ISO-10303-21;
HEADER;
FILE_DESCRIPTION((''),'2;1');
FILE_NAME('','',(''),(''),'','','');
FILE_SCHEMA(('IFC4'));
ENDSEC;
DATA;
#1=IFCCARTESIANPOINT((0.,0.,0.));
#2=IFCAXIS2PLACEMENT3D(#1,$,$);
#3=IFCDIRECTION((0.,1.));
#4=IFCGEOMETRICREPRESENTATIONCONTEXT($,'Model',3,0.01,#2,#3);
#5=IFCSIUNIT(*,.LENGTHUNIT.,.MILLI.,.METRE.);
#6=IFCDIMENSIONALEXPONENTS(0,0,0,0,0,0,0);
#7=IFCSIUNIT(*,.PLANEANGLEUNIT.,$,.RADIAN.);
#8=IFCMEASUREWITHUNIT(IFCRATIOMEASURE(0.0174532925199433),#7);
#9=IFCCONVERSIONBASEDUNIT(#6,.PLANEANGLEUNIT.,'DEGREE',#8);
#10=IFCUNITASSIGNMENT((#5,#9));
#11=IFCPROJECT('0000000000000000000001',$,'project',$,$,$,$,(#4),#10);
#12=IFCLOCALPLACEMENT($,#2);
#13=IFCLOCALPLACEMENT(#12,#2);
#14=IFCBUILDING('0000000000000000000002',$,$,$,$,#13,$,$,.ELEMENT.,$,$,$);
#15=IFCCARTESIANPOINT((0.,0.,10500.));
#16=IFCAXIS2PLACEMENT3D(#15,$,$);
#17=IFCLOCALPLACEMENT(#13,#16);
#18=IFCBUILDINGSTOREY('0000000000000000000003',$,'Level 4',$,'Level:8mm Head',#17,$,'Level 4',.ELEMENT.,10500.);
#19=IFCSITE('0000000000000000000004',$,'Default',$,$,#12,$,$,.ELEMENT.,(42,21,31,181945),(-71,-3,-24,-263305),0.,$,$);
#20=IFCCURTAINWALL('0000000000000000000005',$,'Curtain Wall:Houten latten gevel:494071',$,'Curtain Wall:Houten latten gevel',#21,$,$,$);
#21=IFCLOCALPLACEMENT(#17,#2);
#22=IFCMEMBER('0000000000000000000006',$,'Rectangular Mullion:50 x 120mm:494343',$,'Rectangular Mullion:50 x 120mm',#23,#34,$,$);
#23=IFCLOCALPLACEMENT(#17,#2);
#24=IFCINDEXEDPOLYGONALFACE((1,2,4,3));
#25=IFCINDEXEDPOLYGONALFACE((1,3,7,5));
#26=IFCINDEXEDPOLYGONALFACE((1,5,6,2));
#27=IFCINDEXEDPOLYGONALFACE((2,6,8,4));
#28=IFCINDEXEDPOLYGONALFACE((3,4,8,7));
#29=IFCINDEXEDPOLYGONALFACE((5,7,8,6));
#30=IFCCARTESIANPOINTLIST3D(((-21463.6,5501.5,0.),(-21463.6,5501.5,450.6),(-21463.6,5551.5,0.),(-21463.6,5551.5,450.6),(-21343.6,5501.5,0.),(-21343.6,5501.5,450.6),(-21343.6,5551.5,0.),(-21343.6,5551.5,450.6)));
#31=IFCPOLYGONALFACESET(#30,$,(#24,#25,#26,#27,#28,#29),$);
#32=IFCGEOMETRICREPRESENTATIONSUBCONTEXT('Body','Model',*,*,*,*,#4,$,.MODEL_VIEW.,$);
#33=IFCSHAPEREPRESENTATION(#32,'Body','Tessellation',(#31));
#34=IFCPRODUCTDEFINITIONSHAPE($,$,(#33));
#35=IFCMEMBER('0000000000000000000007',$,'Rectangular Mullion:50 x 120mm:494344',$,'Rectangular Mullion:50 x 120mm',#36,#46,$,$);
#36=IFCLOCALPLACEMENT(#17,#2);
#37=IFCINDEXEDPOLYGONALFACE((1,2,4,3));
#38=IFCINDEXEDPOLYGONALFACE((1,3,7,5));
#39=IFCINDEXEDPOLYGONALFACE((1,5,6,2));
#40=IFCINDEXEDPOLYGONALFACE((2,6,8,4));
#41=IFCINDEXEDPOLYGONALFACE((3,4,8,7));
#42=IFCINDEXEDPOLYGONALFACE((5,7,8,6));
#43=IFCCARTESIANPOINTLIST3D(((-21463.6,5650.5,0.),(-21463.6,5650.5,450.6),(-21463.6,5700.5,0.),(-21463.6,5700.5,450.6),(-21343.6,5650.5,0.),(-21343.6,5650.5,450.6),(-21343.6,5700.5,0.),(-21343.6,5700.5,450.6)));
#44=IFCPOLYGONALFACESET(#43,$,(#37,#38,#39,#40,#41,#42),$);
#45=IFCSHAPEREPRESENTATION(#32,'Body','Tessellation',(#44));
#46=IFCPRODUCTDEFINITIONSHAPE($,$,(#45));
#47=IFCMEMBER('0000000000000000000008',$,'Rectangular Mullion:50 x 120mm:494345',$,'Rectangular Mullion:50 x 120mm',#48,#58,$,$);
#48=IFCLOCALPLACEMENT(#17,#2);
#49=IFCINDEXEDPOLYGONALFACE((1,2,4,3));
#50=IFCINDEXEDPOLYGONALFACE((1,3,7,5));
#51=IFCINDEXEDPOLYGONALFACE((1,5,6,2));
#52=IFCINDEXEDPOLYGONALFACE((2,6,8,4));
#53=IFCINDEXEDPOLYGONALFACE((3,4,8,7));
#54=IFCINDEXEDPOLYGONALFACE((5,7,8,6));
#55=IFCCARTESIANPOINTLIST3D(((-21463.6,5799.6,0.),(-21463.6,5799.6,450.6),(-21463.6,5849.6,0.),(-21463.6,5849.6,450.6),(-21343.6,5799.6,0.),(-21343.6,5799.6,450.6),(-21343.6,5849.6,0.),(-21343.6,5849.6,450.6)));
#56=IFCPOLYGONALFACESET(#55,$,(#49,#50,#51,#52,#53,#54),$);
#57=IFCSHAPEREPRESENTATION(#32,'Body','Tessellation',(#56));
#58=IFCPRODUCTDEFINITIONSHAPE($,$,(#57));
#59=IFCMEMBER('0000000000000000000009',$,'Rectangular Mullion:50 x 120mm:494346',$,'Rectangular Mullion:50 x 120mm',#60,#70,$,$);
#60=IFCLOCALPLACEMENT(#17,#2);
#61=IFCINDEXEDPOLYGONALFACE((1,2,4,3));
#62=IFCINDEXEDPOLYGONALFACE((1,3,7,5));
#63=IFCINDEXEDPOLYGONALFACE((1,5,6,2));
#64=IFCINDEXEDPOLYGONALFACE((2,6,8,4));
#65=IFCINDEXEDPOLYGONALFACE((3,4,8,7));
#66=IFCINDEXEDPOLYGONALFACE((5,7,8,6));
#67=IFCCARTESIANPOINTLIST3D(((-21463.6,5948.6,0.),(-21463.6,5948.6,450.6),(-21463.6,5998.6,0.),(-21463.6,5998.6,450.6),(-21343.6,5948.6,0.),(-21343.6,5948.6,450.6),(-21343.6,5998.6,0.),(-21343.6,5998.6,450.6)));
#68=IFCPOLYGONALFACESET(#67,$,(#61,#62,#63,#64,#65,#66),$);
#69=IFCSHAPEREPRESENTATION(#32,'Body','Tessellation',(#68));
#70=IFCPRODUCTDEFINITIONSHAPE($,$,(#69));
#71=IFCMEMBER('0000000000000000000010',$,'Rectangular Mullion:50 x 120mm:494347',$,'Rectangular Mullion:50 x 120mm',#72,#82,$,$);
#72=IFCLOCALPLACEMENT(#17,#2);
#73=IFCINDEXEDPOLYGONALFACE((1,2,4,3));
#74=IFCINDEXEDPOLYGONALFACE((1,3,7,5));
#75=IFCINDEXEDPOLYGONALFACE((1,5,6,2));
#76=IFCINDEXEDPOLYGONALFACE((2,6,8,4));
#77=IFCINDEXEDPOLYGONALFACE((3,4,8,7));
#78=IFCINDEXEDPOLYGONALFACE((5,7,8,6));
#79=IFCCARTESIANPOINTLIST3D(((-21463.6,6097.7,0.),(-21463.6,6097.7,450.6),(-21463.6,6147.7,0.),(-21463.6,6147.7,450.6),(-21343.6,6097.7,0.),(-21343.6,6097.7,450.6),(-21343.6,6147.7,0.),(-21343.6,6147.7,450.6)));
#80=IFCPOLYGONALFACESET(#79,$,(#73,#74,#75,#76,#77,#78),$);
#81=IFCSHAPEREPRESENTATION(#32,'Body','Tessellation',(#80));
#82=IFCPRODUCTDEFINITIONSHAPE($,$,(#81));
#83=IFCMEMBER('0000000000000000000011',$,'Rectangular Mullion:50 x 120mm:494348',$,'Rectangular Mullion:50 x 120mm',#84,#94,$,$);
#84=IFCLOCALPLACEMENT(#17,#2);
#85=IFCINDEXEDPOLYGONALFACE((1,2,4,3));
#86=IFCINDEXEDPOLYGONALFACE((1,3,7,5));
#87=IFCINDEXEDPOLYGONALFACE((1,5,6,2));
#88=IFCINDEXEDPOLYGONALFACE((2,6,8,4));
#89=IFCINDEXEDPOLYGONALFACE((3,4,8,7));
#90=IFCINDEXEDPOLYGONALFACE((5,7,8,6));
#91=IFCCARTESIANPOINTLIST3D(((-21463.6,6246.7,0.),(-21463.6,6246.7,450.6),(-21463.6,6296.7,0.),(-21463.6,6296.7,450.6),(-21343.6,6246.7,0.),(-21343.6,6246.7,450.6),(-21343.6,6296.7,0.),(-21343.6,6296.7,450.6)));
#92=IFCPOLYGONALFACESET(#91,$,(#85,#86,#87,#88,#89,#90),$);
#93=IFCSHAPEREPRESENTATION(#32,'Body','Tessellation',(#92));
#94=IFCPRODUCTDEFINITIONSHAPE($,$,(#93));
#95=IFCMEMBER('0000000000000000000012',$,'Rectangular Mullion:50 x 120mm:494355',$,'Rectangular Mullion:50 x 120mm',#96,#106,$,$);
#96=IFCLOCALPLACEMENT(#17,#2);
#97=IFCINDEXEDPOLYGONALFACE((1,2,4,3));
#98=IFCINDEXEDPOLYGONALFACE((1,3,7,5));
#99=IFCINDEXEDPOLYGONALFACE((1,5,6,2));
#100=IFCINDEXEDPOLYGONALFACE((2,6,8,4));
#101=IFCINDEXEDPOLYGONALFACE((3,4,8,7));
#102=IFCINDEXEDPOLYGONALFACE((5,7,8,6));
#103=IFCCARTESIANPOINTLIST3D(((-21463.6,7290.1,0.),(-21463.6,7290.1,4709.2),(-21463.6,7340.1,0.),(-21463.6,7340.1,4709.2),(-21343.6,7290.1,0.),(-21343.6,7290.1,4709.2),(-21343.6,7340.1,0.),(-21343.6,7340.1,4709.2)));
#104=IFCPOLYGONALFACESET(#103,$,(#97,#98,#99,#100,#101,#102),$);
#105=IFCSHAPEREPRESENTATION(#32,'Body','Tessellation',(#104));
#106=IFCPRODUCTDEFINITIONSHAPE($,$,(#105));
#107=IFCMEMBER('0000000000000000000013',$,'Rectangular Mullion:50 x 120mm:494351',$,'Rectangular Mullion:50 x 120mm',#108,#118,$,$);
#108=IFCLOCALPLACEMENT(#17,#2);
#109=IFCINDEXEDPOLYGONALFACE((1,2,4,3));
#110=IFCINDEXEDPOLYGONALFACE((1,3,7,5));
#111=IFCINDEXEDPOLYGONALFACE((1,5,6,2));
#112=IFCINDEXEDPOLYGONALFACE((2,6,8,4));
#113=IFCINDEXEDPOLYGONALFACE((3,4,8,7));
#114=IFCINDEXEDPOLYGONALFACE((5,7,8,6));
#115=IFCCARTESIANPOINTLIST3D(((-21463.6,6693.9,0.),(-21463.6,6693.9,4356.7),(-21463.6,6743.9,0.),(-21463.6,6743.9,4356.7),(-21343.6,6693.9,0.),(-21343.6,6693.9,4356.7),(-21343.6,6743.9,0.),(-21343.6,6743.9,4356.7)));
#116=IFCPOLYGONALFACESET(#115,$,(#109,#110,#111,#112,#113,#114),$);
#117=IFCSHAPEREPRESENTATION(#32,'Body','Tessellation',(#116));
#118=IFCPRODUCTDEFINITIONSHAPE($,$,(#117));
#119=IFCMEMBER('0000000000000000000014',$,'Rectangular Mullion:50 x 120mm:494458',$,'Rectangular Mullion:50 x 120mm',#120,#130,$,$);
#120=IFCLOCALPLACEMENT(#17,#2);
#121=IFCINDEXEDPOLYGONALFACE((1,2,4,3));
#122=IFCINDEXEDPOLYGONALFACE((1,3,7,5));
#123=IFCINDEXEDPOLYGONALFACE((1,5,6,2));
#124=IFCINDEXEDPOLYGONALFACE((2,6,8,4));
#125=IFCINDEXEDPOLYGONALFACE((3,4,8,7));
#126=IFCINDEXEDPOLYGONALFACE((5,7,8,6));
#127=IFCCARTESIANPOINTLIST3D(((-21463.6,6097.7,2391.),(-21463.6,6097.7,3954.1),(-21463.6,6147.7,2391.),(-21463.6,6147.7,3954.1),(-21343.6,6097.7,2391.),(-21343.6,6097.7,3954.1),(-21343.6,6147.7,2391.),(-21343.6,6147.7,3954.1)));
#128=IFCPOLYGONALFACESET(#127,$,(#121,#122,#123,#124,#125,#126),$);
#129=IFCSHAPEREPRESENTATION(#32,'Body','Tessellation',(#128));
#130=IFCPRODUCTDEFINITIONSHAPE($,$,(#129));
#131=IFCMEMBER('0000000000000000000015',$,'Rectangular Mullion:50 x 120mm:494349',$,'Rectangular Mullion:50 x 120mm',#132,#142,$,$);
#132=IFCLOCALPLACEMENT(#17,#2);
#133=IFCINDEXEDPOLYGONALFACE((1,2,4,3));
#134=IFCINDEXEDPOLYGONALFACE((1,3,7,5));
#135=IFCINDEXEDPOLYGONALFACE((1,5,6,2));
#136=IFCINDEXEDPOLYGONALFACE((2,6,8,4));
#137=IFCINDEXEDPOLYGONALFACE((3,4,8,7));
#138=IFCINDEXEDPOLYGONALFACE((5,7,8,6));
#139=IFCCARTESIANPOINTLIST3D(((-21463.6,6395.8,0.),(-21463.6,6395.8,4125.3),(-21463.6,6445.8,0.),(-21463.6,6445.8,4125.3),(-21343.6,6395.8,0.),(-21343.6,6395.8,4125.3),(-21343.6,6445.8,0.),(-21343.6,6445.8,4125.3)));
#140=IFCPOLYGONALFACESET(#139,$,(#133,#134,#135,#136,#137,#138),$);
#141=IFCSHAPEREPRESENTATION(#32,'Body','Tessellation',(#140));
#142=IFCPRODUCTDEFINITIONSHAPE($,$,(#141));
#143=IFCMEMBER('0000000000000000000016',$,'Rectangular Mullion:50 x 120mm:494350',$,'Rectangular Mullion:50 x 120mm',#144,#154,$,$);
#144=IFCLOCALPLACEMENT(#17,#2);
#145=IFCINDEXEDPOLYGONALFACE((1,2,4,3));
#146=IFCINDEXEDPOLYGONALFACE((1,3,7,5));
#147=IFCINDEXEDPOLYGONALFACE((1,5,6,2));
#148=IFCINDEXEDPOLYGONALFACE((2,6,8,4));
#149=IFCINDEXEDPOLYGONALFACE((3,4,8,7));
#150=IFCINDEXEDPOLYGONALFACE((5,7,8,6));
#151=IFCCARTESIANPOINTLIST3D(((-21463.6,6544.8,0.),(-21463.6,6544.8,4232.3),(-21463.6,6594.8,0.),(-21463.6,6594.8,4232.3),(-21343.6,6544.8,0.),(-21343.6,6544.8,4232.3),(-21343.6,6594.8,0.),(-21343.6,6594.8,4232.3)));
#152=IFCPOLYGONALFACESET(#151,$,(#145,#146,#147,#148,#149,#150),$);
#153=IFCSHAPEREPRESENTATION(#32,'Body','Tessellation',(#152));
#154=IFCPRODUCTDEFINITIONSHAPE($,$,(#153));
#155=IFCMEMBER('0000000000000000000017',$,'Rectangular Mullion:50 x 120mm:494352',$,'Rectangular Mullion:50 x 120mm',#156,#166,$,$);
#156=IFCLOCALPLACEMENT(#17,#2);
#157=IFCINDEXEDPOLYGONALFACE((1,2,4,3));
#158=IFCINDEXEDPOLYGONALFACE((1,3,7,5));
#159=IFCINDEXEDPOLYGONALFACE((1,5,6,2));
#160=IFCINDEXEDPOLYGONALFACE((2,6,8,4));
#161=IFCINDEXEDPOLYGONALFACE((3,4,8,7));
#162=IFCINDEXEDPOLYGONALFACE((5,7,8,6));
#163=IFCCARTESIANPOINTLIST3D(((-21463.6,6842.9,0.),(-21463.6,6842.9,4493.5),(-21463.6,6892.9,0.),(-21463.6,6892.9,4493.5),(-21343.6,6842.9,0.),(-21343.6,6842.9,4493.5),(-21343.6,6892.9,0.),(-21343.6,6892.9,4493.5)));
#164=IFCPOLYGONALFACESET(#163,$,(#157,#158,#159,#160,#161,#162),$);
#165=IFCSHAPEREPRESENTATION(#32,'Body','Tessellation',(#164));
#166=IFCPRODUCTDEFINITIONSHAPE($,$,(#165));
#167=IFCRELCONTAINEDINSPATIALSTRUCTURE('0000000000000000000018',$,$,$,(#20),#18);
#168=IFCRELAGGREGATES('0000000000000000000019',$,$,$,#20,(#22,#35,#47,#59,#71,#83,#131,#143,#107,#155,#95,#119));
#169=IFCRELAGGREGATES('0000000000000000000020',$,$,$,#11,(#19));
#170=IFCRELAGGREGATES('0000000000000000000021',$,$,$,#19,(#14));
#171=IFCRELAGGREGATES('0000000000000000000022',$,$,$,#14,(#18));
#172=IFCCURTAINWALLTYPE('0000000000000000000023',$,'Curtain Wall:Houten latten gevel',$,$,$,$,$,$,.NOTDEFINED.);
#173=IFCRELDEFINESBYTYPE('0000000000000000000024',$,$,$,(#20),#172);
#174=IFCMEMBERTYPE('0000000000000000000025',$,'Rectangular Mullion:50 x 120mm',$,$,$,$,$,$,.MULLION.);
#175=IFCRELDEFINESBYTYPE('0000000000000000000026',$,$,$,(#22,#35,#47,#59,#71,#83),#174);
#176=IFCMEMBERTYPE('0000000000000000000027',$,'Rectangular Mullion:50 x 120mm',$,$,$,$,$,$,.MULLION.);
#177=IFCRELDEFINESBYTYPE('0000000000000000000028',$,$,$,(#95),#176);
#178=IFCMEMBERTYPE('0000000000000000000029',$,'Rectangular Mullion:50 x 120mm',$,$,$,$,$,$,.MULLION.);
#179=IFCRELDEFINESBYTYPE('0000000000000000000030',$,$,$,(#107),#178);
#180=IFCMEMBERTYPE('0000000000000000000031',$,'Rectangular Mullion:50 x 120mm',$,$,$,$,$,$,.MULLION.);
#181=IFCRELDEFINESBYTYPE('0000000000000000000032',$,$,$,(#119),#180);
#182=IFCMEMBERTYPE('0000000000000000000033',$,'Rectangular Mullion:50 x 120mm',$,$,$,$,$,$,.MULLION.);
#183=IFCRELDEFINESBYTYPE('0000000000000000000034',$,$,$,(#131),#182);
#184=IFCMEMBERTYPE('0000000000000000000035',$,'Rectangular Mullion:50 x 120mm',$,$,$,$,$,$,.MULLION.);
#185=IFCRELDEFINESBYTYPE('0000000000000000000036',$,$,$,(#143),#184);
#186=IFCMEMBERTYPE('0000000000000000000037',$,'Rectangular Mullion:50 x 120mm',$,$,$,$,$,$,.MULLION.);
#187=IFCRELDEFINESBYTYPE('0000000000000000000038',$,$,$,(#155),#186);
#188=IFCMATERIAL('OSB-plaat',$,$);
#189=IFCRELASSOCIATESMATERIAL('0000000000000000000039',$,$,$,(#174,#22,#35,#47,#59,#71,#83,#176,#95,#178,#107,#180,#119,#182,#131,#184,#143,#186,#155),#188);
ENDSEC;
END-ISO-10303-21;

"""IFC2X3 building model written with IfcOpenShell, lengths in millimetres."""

from ifc_helpers import new_model, entity, si_unit, converted_unit, direction, frame, origin, origin_2d_with_axis, place, context, subcontext, project, spatial, rectangle, extrude, source, transform, mapped, material, type_object, type_shapes, element, aggregate, save


model = new_model("IFC2X3")

# Units and contexts
model_context = context("Model", 3, precision=0.01, world=origin(), true_north=direction((0.0, 1.0)))
body_context = subcontext(model_context, "Body", "Model", "MODEL_VIEW")
ifc_project = project(units=[si_unit("LENGTHUNIT", "METRE", prefix="MILLI"), converted_unit("PLANEANGLEUNIT", "DEGREE", entity("IfcRatioMeasure", 0.0174532925199433), si_unit("PLANEANGLEUNIT", "RADIAN"), dimensions=[0, 0, 0, 0, 0, 0, 0])], contexts=[model_context])

# Site, building, storey
site_placement = place(None, frame((0.0, 0.0, 0.0)))
site = spatial("IfcSite", under=ifc_project, at=site_placement, Name="Default", CompositionType="ELEMENT", RefLatitude=(42, 21, 31, 181945), RefLongitude=(-71, -3, -24, -263305), RefElevation=0.0)
building_placement = place(site_placement, origin())
building = spatial("IfcBuilding", under=site, at=building_placement, CompositionType="ELEMENT")
storey_placement = place(building_placement, frame((0.0, 0.0, 10500.0)))
storey = spatial("IfcBuildingStorey", under=building, at=storey_placement, Name="Level 4", ObjectType="Level:8mm Head", LongName="Level 4", CompositionType="ELEMENT", Elevation=10500.0)

# Curtain wall, members
curtain_wall_type = type_object("IfcCurtainWallType", Name="Curtain Wall:Houten latten gevel", PredefinedType="NOTDEFINED")
curtain_wall_placement = place(storey_placement, frame((0.0, 0.0, -10500.0)))
curtain_wall = element("IfcCurtainWall", 1, at=curtain_wall_placement, inside=storey, type_object=curtain_wall_type, Name="Curtain Wall:Houten latten gevel:494071", ObjectType="Curtain Wall:Houten latten gevel")
ifc_material_1 = material(Name="OSB-plaat")
member_type_1 = type_object("IfcMemberType", Name="Rectangular Mullion:50 x 120mm", PredefinedType="MULLION", material=ifc_material_1)
shared_shape_1 = source(origin(), body_context, "Body", "SweptSolid", [
    extrude(rectangle(XDim=120.0, YDim=50.0, at=origin_2d_with_axis()), frame((0.0, 0.0, -450.6), z_axis=(0.0, 0.0, 1.0), x_axis=(0.0, -1.0, 0.0)), (0.0, 0.0, 1.0), 450.6),
])
type_shapes(member_type_1, [shared_shape_1])
placement = place(building_placement, frame((0.0, 0.0, 7500.0)))
member_1_placement = place(placement, frame((-21403.6, 5526.5, 3000.0), z_axis=(0.0, 0.0, -1.0), x_axis=(0.0, 1.0, 0.0)))
member_1 = element("IfcMember", 2, at=member_1_placement, type_object=member_type_1, material=ifc_material_1, Name="Rectangular Mullion:50 x 120mm:494343", ObjectType="Rectangular Mullion:50 x 120mm", context=body_context, shape_type="MappedRepresentation", body=[
    mapped(shared_shape_1, transform((0.0, 0.0, 0.0), scale=1.0)),
])
member_2_placement = place(placement, frame((-21403.6, 5675.5, 3000.0), z_axis=(0.0, 0.0, -1.0), x_axis=(0.0, 1.0, 0.0)))
member_2 = element("IfcMember", 3, at=member_2_placement, type_object=member_type_1, material=ifc_material_1, Name="Rectangular Mullion:50 x 120mm:494344", ObjectType="Rectangular Mullion:50 x 120mm", context=body_context, shape_type="MappedRepresentation", body=[
    mapped(shared_shape_1, transform((0.0, 0.0, 0.0), scale=1.0)),
])
member_3_placement = place(placement, frame((-21403.6, 5824.6, 3000.0), z_axis=(0.0, 0.0, -1.0), x_axis=(0.0, 1.0, 0.0)))
member_3 = element("IfcMember", 4, at=member_3_placement, type_object=member_type_1, material=ifc_material_1, Name="Rectangular Mullion:50 x 120mm:494345", ObjectType="Rectangular Mullion:50 x 120mm", context=body_context, shape_type="MappedRepresentation", body=[
    mapped(shared_shape_1, transform((0.0, 0.0, 0.0), scale=1.0)),
])
member_4_placement = place(placement, frame((-21403.6, 5973.6, 3000.0), z_axis=(0.0, 0.0, -1.0), x_axis=(0.0, 1.0, 0.0)))
member_4 = element("IfcMember", 5, at=member_4_placement, type_object=member_type_1, material=ifc_material_1, Name="Rectangular Mullion:50 x 120mm:494346", ObjectType="Rectangular Mullion:50 x 120mm", context=body_context, shape_type="MappedRepresentation", body=[
    mapped(shared_shape_1, transform((0.0, 0.0, 0.0), scale=1.0)),
])
member_5_placement = place(placement, frame((-21403.6, 6122.7, 3000.0), z_axis=(0.0, 0.0, -1.0), x_axis=(0.0, 1.0, 0.0)))
member_5 = element("IfcMember", 6, at=member_5_placement, type_object=member_type_1, material=ifc_material_1, Name="Rectangular Mullion:50 x 120mm:494347", ObjectType="Rectangular Mullion:50 x 120mm", context=body_context, shape_type="MappedRepresentation", body=[
    mapped(shared_shape_1, transform((0.0, 0.0, 0.0), scale=1.0)),
])
member_6_placement = place(placement, frame((-21403.6, 6271.7, 3000.0), z_axis=(0.0, 0.0, -1.0), x_axis=(0.0, 1.0, 0.0)))
member_6 = element("IfcMember", 7, at=member_6_placement, type_object=member_type_1, material=ifc_material_1, Name="Rectangular Mullion:50 x 120mm:494348", ObjectType="Rectangular Mullion:50 x 120mm", context=body_context, shape_type="MappedRepresentation", body=[
    mapped(shared_shape_1, transform((0.0, 0.0, 0.0), scale=1.0)),
])
member_type_2 = type_object("IfcMemberType", Name="Rectangular Mullion:50 x 120mm", PredefinedType="MULLION", material=ifc_material_1)
shared_shape_2 = source(origin(), body_context, "Body", "SweptSolid", [
    extrude(rectangle(XDim=120.0, YDim=50.0, at=origin_2d_with_axis()), frame((0.0, 0.0, -4709.2), z_axis=(0.0, 0.0, 1.0), x_axis=(0.0, -1.0, 0.0)), (0.0, 0.0, 1.0), 4709.2),
])
type_shapes(member_type_2, [shared_shape_2])
member_7_placement = place(placement, frame((-21403.6, 7315.1, 3000.0), z_axis=(0.0, 0.0, -1.0), x_axis=(0.0, 1.0, 0.0)))
member_7 = element("IfcMember", 8, at=member_7_placement, type_object=member_type_2, material=ifc_material_1, Name="Rectangular Mullion:50 x 120mm:494355", ObjectType="Rectangular Mullion:50 x 120mm", context=body_context, shape_type="MappedRepresentation", body=[
    mapped(shared_shape_2, transform((0.0, 0.0, 0.0), scale=1.0)),
])
member_type_3 = type_object("IfcMemberType", Name="Rectangular Mullion:50 x 120mm", PredefinedType="MULLION", material=ifc_material_1)
shared_shape_3 = source(origin(), body_context, "Body", "SweptSolid", [
    extrude(rectangle(XDim=120.0, YDim=50.0, at=origin_2d_with_axis()), frame((0.0, 0.0, -4356.7), z_axis=(0.0, 0.0, 1.0), x_axis=(0.0, -1.0, 0.0)), (0.0, 0.0, 1.0), 4356.7),
])
type_shapes(member_type_3, [shared_shape_3])
member_8_placement = place(placement, frame((-21403.6, 6718.9, 3000.0), z_axis=(0.0, 0.0, -1.0), x_axis=(0.0, 1.0, 0.0)))
member_8 = element("IfcMember", 9, at=member_8_placement, type_object=member_type_3, material=ifc_material_1, Name="Rectangular Mullion:50 x 120mm:494351", ObjectType="Rectangular Mullion:50 x 120mm", context=body_context, shape_type="MappedRepresentation", body=[
    mapped(shared_shape_3, transform((0.0, 0.0, 0.0), scale=1.0)),
])
member_type_4 = type_object("IfcMemberType", Name="Rectangular Mullion:50 x 120mm", PredefinedType="MULLION", material=ifc_material_1)
shared_shape_4 = source(origin(), body_context, "Body", "SweptSolid", [
    extrude(rectangle(XDim=120.0, YDim=50.0, at=origin_2d_with_axis()), frame((0.0, 0.0, -1563.1), z_axis=(0.0, 0.0, 1.0), x_axis=(0.0, -1.0, 0.0)), (0.0, 0.0, 1.0), 1563.1),
])
type_shapes(member_type_4, [shared_shape_4])
member_9_placement = place(placement, frame((-21403.6, 6122.7, 5391.0), z_axis=(0.0, 0.0, -1.0), x_axis=(0.0, 1.0, 0.0)))
member_9 = element("IfcMember", 10, at=member_9_placement, type_object=member_type_4, material=ifc_material_1, Name="Rectangular Mullion:50 x 120mm:494458", ObjectType="Rectangular Mullion:50 x 120mm", context=body_context, shape_type="MappedRepresentation", body=[
    mapped(shared_shape_4, transform((0.0, 0.0, 0.0), scale=1.0)),
])
member_type_5 = type_object("IfcMemberType", Name="Rectangular Mullion:50 x 120mm", PredefinedType="MULLION", material=ifc_material_1)
shared_shape_5 = source(origin(), body_context, "Body", "SweptSolid", [
    extrude(rectangle(XDim=120.0, YDim=50.0, at=origin_2d_with_axis()), frame((0.0, 0.0, -4125.3), z_axis=(0.0, 0.0, 1.0), x_axis=(0.0, -1.0, 0.0)), (0.0, 0.0, 1.0), 4125.3),
])
type_shapes(member_type_5, [shared_shape_5])
member_10_placement = place(placement, frame((-21403.6, 6420.8, 3000.0), z_axis=(0.0, 0.0, -1.0), x_axis=(0.0, 1.0, 0.0)))
member_10 = element("IfcMember", 11, at=member_10_placement, type_object=member_type_5, material=ifc_material_1, Name="Rectangular Mullion:50 x 120mm:494349", ObjectType="Rectangular Mullion:50 x 120mm", context=body_context, shape_type="MappedRepresentation", body=[
    mapped(shared_shape_5, transform((0.0, 0.0, 0.0), scale=1.0)),
])
member_type_6 = type_object("IfcMemberType", Name="Rectangular Mullion:50 x 120mm", PredefinedType="MULLION", material=ifc_material_1)
shared_shape_6 = source(origin(), body_context, "Body", "SweptSolid", [
    extrude(rectangle(XDim=120.0, YDim=50.0, at=origin_2d_with_axis()), frame((0.0, 0.0, -4232.3), z_axis=(0.0, 0.0, 1.0), x_axis=(0.0, -1.0, 0.0)), (0.0, 0.0, 1.0), 4232.3),
])
type_shapes(member_type_6, [shared_shape_6])
member_11_placement = place(placement, frame((-21403.6, 6569.8, 3000.0), z_axis=(0.0, 0.0, -1.0), x_axis=(0.0, 1.0, 0.0)))
member_11 = element("IfcMember", 12, at=member_11_placement, type_object=member_type_6, material=ifc_material_1, Name="Rectangular Mullion:50 x 120mm:494350", ObjectType="Rectangular Mullion:50 x 120mm", context=body_context, shape_type="MappedRepresentation", body=[
    mapped(shared_shape_6, transform((0.0, 0.0, 0.0), scale=1.0)),
])
member_type_7 = type_object("IfcMemberType", Name="Rectangular Mullion:50 x 120mm", PredefinedType="MULLION", material=ifc_material_1)
shared_shape_7 = source(origin(), body_context, "Body", "SweptSolid", [
    extrude(rectangle(XDim=120.0, YDim=50.0, at=origin_2d_with_axis()), frame((0.0, 0.0, -4493.5), z_axis=(0.0, 0.0, 1.0), x_axis=(0.0, -1.0, 0.0)), (0.0, 0.0, 1.0), 4493.5),
])
type_shapes(member_type_7, [shared_shape_7])
member_12_placement = place(placement, frame((-21403.6, 6867.9, 3000.0), z_axis=(0.0, 0.0, -1.0), x_axis=(0.0, 1.0, 0.0)))
member_12 = element("IfcMember", 13, at=member_12_placement, type_object=member_type_7, material=ifc_material_1, Name="Rectangular Mullion:50 x 120mm:494352", ObjectType="Rectangular Mullion:50 x 120mm", context=body_context, shape_type="MappedRepresentation", body=[
    mapped(shared_shape_7, transform((0.0, 0.0, 0.0), scale=1.0)),
])
aggregate(curtain_wall, [member_1, member_2, member_3, member_4, member_5, member_6, member_10, member_11, member_8, member_12, member_7, member_9])

save(model, "model.ifc")
